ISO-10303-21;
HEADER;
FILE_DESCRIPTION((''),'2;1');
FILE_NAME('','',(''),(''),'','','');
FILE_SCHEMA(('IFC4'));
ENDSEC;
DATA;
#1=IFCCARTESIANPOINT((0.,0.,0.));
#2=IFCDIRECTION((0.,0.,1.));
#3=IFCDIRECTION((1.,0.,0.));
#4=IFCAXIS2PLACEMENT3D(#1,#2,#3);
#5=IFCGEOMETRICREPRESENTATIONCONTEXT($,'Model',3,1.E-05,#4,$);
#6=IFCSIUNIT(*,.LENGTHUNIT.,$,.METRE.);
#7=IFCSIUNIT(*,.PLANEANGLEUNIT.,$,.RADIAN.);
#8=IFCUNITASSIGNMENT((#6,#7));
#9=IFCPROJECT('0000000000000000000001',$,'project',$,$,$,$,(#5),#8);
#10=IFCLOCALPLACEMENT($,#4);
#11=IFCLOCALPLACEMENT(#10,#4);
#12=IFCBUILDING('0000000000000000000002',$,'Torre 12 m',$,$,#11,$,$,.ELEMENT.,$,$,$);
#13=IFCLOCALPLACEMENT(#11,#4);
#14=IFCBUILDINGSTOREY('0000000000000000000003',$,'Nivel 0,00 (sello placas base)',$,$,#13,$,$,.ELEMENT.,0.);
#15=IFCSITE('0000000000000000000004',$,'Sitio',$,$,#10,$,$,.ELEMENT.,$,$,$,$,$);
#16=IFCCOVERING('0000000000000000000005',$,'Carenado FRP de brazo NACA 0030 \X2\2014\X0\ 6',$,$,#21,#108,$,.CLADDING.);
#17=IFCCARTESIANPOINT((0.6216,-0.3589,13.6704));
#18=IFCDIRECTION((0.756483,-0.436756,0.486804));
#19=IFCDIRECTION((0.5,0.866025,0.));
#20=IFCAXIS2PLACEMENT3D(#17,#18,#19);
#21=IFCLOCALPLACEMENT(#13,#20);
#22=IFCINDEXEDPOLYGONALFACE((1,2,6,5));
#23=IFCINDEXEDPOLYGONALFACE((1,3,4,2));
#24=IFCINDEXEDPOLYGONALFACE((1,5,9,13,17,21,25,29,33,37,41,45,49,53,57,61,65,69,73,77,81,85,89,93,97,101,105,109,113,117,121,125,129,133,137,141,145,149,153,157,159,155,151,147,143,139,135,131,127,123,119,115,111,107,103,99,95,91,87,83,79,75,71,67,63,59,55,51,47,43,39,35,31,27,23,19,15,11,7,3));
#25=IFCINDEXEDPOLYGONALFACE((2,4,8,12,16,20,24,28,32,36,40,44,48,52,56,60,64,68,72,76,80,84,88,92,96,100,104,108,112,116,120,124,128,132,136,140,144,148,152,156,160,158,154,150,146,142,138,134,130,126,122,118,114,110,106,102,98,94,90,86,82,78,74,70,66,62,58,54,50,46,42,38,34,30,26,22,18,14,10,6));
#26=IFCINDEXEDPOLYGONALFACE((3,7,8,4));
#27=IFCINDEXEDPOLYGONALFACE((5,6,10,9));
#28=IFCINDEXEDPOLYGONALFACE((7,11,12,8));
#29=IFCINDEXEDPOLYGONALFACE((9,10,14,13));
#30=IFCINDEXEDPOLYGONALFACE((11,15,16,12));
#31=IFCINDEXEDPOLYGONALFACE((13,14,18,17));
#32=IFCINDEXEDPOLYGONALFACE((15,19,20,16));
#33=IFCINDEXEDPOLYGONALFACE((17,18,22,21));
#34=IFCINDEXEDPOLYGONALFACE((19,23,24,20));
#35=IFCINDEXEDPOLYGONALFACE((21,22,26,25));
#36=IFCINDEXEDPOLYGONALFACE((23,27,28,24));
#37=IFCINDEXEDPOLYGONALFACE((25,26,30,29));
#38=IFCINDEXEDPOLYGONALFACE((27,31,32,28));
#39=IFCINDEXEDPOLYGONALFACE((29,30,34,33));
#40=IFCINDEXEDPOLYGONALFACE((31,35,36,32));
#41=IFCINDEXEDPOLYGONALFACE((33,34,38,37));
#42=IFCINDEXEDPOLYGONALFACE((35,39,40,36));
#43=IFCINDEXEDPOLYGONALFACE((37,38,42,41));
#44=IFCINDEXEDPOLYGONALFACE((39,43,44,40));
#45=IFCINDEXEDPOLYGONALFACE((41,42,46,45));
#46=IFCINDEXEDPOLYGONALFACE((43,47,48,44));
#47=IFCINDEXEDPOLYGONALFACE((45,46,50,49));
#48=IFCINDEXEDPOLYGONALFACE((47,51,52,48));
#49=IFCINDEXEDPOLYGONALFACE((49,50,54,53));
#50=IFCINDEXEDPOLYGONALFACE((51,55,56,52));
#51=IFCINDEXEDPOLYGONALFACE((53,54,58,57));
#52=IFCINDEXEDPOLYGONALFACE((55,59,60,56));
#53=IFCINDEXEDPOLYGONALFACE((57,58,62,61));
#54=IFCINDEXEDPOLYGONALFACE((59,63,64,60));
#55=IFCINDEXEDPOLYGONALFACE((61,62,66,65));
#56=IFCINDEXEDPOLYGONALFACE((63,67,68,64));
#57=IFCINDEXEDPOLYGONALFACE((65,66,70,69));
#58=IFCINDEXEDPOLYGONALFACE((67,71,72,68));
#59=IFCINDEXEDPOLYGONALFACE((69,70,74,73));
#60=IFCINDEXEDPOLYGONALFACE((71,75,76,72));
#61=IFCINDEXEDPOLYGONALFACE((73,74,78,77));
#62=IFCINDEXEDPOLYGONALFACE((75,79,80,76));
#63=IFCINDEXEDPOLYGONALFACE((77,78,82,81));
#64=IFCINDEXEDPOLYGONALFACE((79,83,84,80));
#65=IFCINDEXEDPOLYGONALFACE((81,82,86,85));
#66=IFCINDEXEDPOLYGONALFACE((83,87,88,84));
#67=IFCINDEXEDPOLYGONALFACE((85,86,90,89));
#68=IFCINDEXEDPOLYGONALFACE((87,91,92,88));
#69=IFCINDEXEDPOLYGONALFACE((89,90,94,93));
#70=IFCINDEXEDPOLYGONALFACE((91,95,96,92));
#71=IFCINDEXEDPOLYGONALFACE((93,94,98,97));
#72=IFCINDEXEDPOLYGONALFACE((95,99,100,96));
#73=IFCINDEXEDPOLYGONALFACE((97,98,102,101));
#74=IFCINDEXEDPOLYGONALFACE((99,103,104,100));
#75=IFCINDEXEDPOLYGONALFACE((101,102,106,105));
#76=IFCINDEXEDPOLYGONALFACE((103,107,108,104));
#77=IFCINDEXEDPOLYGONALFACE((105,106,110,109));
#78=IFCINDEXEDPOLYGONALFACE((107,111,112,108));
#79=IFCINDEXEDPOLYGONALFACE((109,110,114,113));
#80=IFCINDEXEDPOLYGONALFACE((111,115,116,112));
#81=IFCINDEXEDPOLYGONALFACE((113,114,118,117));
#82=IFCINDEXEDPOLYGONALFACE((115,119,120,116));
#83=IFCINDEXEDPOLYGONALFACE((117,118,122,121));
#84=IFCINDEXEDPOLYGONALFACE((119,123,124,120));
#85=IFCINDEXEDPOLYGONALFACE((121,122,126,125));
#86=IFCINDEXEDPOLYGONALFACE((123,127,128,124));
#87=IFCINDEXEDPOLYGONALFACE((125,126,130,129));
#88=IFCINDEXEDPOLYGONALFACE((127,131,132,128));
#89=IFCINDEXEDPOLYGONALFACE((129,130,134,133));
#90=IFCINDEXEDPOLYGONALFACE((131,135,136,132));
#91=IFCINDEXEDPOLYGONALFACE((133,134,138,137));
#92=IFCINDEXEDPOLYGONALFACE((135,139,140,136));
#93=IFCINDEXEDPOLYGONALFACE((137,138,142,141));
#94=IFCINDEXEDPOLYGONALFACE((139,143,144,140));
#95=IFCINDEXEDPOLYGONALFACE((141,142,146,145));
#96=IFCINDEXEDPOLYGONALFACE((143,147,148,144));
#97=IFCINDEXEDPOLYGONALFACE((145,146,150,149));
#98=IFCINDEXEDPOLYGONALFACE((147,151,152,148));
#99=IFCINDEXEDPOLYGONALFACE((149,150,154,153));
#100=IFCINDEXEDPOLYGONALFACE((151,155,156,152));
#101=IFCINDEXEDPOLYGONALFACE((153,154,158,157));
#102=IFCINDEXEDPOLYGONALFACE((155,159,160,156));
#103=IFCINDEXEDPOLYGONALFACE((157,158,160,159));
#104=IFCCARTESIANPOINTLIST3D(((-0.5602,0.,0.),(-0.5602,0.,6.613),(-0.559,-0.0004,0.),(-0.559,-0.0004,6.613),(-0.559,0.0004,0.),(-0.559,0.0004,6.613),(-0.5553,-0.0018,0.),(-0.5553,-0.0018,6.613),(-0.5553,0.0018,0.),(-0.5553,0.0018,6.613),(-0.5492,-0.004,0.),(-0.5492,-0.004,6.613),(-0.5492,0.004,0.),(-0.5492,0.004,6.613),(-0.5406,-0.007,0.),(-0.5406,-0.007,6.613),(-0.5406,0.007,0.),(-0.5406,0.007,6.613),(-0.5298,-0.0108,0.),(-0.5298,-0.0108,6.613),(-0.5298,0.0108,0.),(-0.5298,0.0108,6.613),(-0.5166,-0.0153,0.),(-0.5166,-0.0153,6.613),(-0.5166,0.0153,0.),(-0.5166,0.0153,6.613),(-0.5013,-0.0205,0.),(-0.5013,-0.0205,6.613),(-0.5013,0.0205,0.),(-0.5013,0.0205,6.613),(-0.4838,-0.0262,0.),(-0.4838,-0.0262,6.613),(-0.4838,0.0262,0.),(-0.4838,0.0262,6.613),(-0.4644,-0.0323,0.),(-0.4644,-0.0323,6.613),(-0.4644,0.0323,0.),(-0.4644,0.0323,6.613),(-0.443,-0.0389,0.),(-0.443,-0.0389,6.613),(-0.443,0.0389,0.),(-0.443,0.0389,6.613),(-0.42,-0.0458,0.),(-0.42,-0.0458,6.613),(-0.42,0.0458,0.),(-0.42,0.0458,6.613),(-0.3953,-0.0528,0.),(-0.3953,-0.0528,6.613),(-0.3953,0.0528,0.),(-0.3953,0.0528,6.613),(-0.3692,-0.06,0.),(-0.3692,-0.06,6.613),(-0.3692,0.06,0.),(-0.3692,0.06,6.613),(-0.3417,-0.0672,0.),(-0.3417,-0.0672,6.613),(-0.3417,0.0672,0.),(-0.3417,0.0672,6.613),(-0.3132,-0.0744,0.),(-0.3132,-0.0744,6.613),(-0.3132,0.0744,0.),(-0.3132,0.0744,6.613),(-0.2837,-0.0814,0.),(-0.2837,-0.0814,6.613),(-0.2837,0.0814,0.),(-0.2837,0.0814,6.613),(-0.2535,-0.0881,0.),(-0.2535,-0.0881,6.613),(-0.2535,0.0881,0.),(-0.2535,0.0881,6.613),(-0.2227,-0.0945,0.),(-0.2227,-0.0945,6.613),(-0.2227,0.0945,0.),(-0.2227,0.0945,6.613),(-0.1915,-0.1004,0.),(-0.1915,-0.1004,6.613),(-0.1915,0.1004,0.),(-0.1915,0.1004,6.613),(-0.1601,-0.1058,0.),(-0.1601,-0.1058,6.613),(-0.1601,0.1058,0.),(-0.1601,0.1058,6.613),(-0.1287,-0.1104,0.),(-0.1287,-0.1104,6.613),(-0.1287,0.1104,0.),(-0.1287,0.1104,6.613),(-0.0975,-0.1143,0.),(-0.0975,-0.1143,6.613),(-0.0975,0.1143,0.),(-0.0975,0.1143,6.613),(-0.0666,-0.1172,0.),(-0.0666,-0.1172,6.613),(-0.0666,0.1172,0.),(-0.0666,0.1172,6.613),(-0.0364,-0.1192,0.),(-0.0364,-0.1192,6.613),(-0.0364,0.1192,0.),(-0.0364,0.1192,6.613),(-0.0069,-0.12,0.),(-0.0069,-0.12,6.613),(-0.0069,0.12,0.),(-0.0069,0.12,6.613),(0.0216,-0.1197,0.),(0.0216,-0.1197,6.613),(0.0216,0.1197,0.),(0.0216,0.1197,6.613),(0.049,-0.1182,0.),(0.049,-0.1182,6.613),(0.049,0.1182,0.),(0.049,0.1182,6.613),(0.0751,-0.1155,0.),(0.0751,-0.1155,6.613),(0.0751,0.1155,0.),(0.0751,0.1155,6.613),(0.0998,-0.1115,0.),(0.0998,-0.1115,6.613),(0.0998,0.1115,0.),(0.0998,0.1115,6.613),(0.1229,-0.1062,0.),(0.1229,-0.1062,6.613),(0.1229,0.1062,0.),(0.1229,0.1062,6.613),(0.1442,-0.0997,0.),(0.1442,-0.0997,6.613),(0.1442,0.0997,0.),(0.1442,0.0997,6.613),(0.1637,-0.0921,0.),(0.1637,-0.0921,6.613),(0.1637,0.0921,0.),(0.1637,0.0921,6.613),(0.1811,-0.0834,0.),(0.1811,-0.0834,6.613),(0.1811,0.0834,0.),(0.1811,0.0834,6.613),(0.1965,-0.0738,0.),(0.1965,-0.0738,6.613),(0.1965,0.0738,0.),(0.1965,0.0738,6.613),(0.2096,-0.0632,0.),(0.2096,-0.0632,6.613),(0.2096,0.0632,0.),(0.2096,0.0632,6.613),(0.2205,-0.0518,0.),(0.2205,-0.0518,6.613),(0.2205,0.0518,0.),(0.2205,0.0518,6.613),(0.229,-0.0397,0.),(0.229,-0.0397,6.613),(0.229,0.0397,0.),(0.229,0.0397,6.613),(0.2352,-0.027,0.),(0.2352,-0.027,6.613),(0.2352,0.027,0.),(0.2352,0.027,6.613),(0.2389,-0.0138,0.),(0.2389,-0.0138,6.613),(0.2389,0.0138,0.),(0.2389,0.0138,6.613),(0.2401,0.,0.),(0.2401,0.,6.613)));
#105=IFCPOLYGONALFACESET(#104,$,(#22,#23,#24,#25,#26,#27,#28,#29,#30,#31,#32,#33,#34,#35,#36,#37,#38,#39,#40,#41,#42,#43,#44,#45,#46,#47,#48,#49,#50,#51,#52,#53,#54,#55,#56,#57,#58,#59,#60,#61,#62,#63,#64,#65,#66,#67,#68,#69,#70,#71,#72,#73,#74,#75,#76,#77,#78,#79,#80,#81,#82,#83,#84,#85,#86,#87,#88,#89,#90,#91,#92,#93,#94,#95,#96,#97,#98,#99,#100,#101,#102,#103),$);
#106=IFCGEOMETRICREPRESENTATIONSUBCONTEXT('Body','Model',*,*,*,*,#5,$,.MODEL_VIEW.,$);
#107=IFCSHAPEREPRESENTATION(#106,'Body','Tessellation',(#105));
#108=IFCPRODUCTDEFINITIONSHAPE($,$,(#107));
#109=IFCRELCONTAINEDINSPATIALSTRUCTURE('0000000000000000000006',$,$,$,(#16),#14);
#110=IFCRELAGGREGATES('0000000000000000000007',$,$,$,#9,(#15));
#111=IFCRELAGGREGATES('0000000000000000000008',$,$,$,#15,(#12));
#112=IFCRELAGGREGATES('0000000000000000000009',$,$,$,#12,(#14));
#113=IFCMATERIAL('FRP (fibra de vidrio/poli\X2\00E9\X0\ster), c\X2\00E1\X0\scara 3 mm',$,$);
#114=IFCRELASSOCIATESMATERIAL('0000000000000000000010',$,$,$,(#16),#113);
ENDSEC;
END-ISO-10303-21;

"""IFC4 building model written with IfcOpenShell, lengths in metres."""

from ifc_helpers import new_model, si_unit, frame, origin, origin_with_axes, place, context, subcontext, project, spatial, polyline, outline, extrude, material, element, save


model = new_model("IFC4")

# Units and contexts
model_context = context("Model", 3, precision=1e-05, world=origin_with_axes())
body_context = subcontext(model_context, "Body", "Model", "MODEL_VIEW")
ifc_project = project(units=[si_unit("LENGTHUNIT", "METRE"), si_unit("PLANEANGLEUNIT", "RADIAN")], contexts=[model_context])

# Site, building, storey
site_placement = place(None, origin_with_axes())
site = spatial("IfcSite", under=ifc_project, at=site_placement, Name="Sitio", CompositionType="ELEMENT")
building_placement = place(site_placement, origin_with_axes())
building = spatial("IfcBuilding", under=site, at=building_placement, Name="Torre 12 m", CompositionType="ELEMENT")
storey_placement = place(building_placement, origin_with_axes())
storey = spatial("IfcBuildingStorey", under=building, at=storey_placement, Name="Nivel 0,00 (sello placas base)", CompositionType="ELEMENT", Elevation=0.0)

# Covering
ifc_material_1 = material(Name="FRP (fibra de vidrio/poliéster), cáscara 3 mm")
covering_1_placement = place(storey_placement, frame((0.6216, -0.3589, 13.6704), z_axis=(0.756483, -0.436756, 0.486804), x_axis=(0.5, 0.866025, 0.0)))
element("IfcCovering", 1, at=covering_1_placement, inside=storey, material=ifc_material_1, Name="Carenado FRP de brazo NACA 0030 — 6", PredefinedType="CLADDING", context=body_context, shape_type="SweptSolid", body=[
    extrude(outline(polyline([(0.2401, 0.0), (0.2389, 0.0138), (0.2352, 0.027), (0.229, 0.0397), (0.2205, 0.0518), (0.2096, 0.0632), (0.1965, 0.0738), (0.1811, 0.0834), (0.1637, 0.0921), (0.1442, 0.0997), (0.1229, 0.1062), (0.0998, 0.1115), (0.0751, 0.1155), (0.049, 0.1182), (0.0216, 0.1197), (-0.0069, 0.12), (-0.0364, 0.1192), (-0.0666, 0.1172), (-0.0975, 0.1143), (-0.1287, 0.1104), (-0.1601, 0.1058), (-0.1915, 0.1004), (-0.2227, 0.0945), (-0.2535, 0.0881), (-0.2837, 0.0814), (-0.3132, 0.0744), (-0.3417, 0.0672), (-0.3692, 0.06), (-0.3953, 0.0528), (-0.42, 0.0458), (-0.443, 0.0389), (-0.4644, 0.0323), (-0.4838, 0.0262), (-0.5013, 0.0205), (-0.5166, 0.0153), (-0.5298, 0.0108), (-0.5406, 0.007), (-0.5492, 0.004), (-0.5553, 0.0018), (-0.559, 0.0004), (-0.5602, 0.0), (-0.559, -0.0004), (-0.5553, -0.0018), (-0.5492, -0.004), (-0.5406, -0.007), (-0.5298, -0.0108), (-0.5166, -0.0153), (-0.5013, -0.0205), (-0.4838, -0.0262), (-0.4644, -0.0323), (-0.443, -0.0389), (-0.42, -0.0458), (-0.3953, -0.0528), (-0.3692, -0.06), (-0.3417, -0.0672), (-0.3132, -0.0744), (-0.2837, -0.0814), (-0.2535, -0.0881), (-0.2227, -0.0945), (-0.1915, -0.1004), (-0.1601, -0.1058), (-0.1287, -0.1104), (-0.0975, -0.1143), (-0.0666, -0.1172), (-0.0364, -0.1192), (-0.0069, -0.12), (0.0216, -0.1197), (0.049, -0.1182), (0.0751, -0.1155), (0.0998, -0.1115), (0.1229, -0.1062), (0.1442, -0.0997), (0.1637, -0.0921), (0.1811, -0.0834), (0.1965, -0.0738), (0.2096, -0.0632), (0.2205, -0.0518), (0.229, -0.0397), (0.2352, -0.027), (0.2389, -0.0138), (0.2401, 0.0)])), origin(), (0.0, 0.0, 1.0), 6.613),
])

save(model, "model.ifc")
